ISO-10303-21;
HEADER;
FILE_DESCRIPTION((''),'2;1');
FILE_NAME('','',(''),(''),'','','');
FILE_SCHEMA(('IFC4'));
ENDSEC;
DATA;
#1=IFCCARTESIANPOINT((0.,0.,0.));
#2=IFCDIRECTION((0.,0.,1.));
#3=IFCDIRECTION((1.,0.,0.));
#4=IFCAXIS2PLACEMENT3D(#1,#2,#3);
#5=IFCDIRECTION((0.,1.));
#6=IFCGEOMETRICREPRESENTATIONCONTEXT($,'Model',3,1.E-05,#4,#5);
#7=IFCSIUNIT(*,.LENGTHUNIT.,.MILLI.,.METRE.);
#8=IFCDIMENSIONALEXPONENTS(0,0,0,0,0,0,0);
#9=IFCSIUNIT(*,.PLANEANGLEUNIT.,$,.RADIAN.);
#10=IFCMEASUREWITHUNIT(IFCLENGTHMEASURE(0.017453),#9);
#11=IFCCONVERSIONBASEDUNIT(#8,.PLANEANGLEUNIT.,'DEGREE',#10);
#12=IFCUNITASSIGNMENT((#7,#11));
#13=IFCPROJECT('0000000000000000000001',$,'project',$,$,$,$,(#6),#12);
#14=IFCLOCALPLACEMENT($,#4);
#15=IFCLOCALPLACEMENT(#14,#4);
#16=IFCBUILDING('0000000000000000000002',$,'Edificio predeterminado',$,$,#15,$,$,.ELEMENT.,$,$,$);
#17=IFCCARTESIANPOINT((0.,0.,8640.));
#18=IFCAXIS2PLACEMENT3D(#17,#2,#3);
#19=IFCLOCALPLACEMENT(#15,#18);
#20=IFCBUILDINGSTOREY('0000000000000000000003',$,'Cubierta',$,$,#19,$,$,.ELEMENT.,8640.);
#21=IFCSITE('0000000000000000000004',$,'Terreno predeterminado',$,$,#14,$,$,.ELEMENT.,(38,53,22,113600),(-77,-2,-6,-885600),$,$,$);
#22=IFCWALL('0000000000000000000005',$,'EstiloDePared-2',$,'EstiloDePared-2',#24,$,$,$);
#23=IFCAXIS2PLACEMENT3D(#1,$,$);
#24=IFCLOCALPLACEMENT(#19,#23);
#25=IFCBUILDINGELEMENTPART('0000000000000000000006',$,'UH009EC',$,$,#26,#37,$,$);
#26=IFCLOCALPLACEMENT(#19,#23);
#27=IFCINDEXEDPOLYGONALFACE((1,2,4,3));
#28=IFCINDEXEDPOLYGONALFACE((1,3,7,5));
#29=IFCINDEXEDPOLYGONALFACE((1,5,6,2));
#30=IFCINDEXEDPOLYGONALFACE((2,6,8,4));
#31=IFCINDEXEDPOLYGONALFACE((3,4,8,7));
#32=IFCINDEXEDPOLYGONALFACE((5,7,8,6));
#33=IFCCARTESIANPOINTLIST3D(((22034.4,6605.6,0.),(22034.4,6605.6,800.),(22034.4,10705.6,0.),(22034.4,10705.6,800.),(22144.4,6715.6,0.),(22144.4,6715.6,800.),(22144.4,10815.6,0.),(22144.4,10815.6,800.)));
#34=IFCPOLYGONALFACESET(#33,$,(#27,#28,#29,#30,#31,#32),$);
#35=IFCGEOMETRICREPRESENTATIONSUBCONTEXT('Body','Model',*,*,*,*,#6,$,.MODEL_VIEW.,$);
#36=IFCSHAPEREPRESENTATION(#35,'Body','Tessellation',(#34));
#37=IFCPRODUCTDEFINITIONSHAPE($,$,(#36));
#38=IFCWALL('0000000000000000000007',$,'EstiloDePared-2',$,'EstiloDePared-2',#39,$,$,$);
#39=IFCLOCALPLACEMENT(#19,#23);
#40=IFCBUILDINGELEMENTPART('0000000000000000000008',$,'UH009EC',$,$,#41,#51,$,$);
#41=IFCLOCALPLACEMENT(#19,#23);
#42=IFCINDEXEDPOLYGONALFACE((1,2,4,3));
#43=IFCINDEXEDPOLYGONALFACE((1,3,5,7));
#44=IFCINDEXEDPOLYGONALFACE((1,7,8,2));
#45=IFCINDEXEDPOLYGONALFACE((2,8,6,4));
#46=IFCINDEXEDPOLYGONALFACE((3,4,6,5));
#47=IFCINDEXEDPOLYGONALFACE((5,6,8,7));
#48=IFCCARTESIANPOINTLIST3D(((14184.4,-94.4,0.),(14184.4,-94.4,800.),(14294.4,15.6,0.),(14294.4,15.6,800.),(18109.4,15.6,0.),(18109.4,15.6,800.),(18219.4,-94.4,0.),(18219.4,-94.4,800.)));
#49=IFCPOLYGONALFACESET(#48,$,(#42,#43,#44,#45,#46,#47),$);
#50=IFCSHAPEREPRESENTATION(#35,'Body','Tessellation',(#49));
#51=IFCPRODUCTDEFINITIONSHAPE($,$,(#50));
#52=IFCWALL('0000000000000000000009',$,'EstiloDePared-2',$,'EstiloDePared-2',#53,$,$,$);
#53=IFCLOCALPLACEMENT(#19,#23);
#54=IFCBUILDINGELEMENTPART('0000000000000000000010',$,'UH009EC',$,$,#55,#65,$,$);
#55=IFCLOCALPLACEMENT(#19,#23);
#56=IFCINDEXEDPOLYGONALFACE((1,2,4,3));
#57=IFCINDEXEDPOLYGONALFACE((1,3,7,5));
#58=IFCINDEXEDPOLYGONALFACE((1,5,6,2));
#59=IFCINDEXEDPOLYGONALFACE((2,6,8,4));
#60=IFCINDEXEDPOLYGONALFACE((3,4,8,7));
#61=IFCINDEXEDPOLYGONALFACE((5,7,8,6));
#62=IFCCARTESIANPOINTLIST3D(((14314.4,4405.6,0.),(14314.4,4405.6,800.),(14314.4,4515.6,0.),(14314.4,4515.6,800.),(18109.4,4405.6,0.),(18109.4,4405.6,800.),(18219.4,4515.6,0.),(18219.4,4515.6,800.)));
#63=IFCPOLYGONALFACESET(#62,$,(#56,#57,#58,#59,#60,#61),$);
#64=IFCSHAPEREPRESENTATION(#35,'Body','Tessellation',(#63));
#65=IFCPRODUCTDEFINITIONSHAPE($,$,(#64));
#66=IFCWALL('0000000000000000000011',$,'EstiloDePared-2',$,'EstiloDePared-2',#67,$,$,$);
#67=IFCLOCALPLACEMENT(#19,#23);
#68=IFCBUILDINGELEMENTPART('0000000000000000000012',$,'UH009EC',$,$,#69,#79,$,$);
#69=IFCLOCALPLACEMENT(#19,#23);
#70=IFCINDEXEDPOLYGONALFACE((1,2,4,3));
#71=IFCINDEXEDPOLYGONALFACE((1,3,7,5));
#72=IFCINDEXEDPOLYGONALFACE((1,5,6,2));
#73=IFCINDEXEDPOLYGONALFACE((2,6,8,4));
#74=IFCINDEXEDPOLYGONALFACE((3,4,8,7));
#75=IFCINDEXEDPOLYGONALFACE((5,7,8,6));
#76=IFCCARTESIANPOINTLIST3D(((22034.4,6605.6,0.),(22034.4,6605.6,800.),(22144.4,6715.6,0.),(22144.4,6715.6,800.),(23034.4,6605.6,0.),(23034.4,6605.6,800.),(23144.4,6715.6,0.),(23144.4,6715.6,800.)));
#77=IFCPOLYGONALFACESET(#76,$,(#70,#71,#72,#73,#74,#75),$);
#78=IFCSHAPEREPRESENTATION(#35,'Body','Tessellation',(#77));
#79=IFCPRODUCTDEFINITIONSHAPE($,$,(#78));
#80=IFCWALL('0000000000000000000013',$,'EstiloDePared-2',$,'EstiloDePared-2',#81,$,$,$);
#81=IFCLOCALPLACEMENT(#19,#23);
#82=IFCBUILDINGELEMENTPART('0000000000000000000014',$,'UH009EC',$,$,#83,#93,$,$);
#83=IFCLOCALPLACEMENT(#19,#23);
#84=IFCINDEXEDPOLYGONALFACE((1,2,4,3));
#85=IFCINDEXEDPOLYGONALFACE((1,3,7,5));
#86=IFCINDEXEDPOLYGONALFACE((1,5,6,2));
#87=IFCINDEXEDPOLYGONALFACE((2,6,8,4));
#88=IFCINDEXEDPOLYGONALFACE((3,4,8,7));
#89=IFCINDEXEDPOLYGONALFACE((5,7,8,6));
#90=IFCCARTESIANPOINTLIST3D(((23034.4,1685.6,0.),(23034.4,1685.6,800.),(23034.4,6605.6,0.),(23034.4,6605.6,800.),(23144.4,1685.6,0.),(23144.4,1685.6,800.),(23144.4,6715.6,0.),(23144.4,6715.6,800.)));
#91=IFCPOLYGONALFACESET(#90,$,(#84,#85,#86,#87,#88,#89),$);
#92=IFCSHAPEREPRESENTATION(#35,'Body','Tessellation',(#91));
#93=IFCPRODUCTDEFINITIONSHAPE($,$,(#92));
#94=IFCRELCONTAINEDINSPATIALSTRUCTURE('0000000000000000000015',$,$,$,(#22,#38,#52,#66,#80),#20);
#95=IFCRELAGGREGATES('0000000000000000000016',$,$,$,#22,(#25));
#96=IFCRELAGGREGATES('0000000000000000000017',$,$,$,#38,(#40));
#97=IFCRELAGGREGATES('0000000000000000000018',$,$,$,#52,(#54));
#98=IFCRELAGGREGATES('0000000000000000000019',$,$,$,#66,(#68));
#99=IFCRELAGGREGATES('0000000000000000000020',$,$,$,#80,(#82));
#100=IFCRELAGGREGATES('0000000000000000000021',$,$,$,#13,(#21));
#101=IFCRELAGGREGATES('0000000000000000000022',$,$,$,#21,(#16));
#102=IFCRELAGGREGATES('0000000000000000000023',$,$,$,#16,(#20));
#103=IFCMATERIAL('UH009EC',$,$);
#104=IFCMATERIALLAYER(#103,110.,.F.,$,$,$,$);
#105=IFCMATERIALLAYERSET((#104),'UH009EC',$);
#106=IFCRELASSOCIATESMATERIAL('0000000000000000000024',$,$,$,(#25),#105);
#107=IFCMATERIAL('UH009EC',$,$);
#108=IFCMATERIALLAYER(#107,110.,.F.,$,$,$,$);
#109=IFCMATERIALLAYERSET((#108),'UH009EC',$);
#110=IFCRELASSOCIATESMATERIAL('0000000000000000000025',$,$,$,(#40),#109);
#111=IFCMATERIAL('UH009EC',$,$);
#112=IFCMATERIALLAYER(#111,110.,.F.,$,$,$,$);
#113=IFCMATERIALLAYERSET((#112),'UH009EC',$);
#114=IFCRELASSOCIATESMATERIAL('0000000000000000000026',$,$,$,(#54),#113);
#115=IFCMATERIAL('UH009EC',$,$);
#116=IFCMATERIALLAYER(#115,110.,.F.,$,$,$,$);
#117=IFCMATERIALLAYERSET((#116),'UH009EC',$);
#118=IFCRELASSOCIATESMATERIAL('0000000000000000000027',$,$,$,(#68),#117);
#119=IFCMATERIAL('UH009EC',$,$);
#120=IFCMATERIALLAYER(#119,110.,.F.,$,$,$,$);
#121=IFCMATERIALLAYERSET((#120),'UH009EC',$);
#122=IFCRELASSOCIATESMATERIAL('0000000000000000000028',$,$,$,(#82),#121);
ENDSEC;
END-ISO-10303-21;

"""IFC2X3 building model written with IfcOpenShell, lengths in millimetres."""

from ifc_helpers import new_model, entity, si_unit, converted_unit, direction, frame, origin_with_axes, place, context, subcontext, project, spatial, polyline, outline, extrude, material, layer, layer_set, layer_usage, element, aggregate, save


model = new_model("IFC2X3")

# Units and contexts
model_context = context("Model", 3, precision=1e-05, world=origin_with_axes(), true_north=direction((0.0, 1.0)))
body_context = subcontext(model_context, "Body", "Model", "MODEL_VIEW")
ifc_project = project(units=[si_unit("LENGTHUNIT", "METRE", prefix="MILLI"), converted_unit("PLANEANGLEUNIT", "DEGREE", entity("IfcLengthMeasure", 0.017453), si_unit("PLANEANGLEUNIT", "RADIAN"), dimensions=[0, 0, 0, 0, 0, 0, 0])], contexts=[model_context])

# Site, building, storey
site_placement = place(None, origin_with_axes())
site = spatial("IfcSite", under=ifc_project, at=site_placement, Name="Terreno predeterminado", CompositionType="ELEMENT", RefLatitude=(38, 53, 22, 113600), RefLongitude=(-77, -2, -6, -885600))
building_placement = place(site_placement, origin_with_axes())
building = spatial("IfcBuilding", under=site, at=building_placement, Name="Edificio predeterminado", CompositionType="ELEMENT")
storey_placement = place(building_placement, frame((0.0, 0.0, 8640.0), z_axis=(0.0, 0.0, 1.0), x_axis=(1.0, 0.0, 0.0)))
storey = spatial("IfcBuildingStorey", under=building, at=storey_placement, Name="Cubierta", CompositionType="ELEMENT", Elevation=8640.0)

# Wall, building element part
wall_1_placement = place(storey_placement, frame((22089.4, 10760.6, 0.0), z_axis=(0.0, 0.0, 1.0), x_axis=(0.0, -1.0, 0.0)))
wall_1 = element("IfcWall", 1, at=wall_1_placement, inside=storey, Name="EstiloDePared-2", ObjectType="EstiloDePared-2")
ifc_material_1 = material(Name="UH009EC")
ifc_layer_1 = layer(ifc_material_1, 110.0, ventilated=False)
ifc_layer_set_1 = layer_set([ifc_layer_1], Name="UH009EC")
ifc_layer_usage_1 = layer_usage(ifc_layer_set_1, "AXIS2", "NEGATIVE", -55.0)
building_element_part_1_placement = place(wall_1_placement, origin_with_axes())
building_element_part_1 = element("IfcBuildingElementPart", 2, at=building_element_part_1_placement, material=ifc_layer_usage_1, Name="UH009EC", context=body_context, shape_type="SweptSolid", body=[
    extrude(outline(polyline([(4045.0, 55.0), (4155.0, -55.0), (55.0, -55.0), (-55.0, 55.0), (4045.0, 55.0)])), origin_with_axes(), (0.0, 0.0, 1.0), 800.0),
])
aggregate(wall_1, [building_element_part_1])

# Walls, building element parts
wall_2_placement = place(storey_placement, frame((18164.4, -39.4, 0.0), z_axis=(0.0, 0.0, 1.0), x_axis=(-1.0, 0.0, 0.0)))
wall_2 = element("IfcWall", 3, at=wall_2_placement, inside=storey, Name="EstiloDePared-2", ObjectType="EstiloDePared-2")
ifc_material_2 = material(Name="UH009EC")
ifc_layer_2 = layer(ifc_material_2, 110.0, ventilated=False)
ifc_layer_set_2 = layer_set([ifc_layer_2], Name="UH009EC")
ifc_layer_usage_2 = layer_usage(ifc_layer_set_2, "AXIS2", "NEGATIVE", -55.0)
building_element_part_2_placement = place(wall_2_placement, origin_with_axes())
building_element_part_2 = element("IfcBuildingElementPart", 4, at=building_element_part_2_placement, material=ifc_layer_usage_2, Name="UH009EC", context=body_context, shape_type="SweptSolid", body=[
    extrude(outline(polyline([(3980.0, 55.0), (3870.0, -55.0), (55.0, -55.0), (-55.0, 55.0), (3980.0, 55.0)])), origin_with_axes(), (0.0, 0.0, 1.0), 800.0),
])
aggregate(wall_2, [building_element_part_2])
wall_3_placement = place(storey_placement, frame((18164.4, 4460.6, 0.0), z_axis=(0.0, 0.0, 1.0), x_axis=(-1.0, 0.0, 0.0)))
wall_3 = element("IfcWall", 5, at=wall_3_placement, inside=storey, Name="EstiloDePared-2", ObjectType="EstiloDePared-2")
ifc_material_3 = material(Name="UH009EC")
ifc_layer_3 = layer(ifc_material_3, 110.0, ventilated=False)
ifc_layer_set_3 = layer_set([ifc_layer_3], Name="UH009EC")
ifc_layer_usage_3 = layer_usage(ifc_layer_set_3, "AXIS2", "NEGATIVE", -55.0)
building_element_part_3_placement = place(wall_3_placement, origin_with_axes())
building_element_part_3 = element("IfcBuildingElementPart", 6, at=building_element_part_3_placement, material=ifc_layer_usage_3, Name="UH009EC", context=body_context, shape_type="SweptSolid", body=[
    extrude(outline(polyline([(3850.0, 55.0), (3850.0, -55.0), (-55.0, -55.0), (55.0, 55.0), (3850.0, 55.0)])), origin_with_axes(), (0.0, 0.0, 1.0), 800.0),
])
aggregate(wall_3, [building_element_part_3])
wall_4_placement = place(storey_placement, frame((22089.4, 6660.6, 0.0), z_axis=(0.0, 0.0, 1.0), x_axis=(1.0, 0.0, 0.0)))
wall_4 = element("IfcWall", 7, at=wall_4_placement, inside=storey, Name="EstiloDePared-2", ObjectType="EstiloDePared-2")
ifc_material_4 = material(Name="UH009EC")
ifc_layer_4 = layer(ifc_material_4, 110.0, ventilated=False)
ifc_layer_set_4 = layer_set([ifc_layer_4], Name="UH009EC")
ifc_layer_usage_4 = layer_usage(ifc_layer_set_4, "AXIS2", "NEGATIVE", -55.0)
building_element_part_4_placement = place(wall_4_placement, origin_with_axes())
building_element_part_4 = element("IfcBuildingElementPart", 8, at=building_element_part_4_placement, material=ifc_layer_usage_4, Name="UH009EC", context=body_context, shape_type="SweptSolid", body=[
    extrude(outline(polyline([(1055.0, 55.0), (945.0, -55.0), (-55.0, -55.0), (55.0, 55.0), (1055.0, 55.0)])), origin_with_axes(), (0.0, 0.0, 1.0), 800.0),
])
aggregate(wall_4, [building_element_part_4])
wall_5_placement = place(storey_placement, frame((23089.4, 6660.6, 0.0), z_axis=(0.0, 0.0, 1.0), x_axis=(0.0, -1.0, 0.0)))
wall_5 = element("IfcWall", 9, at=wall_5_placement, inside=storey, Name="EstiloDePared-2", ObjectType="EstiloDePared-2")
ifc_material_5 = material(Name="UH009EC")
ifc_layer_5 = layer(ifc_material_5, 110.0, ventilated=False)
ifc_layer_set_5 = layer_set([ifc_layer_5], Name="UH009EC")
ifc_layer_usage_5 = layer_usage(ifc_layer_set_5, "AXIS2", "NEGATIVE", -55.0)
building_element_part_5_placement = place(wall_5_placement, origin_with_axes())
building_element_part_5 = element("IfcBuildingElementPart", 10, at=building_element_part_5_placement, material=ifc_layer_usage_5, Name="UH009EC", context=body_context, shape_type="SweptSolid", body=[
    extrude(outline(polyline([(4975.0, 55.0), (4975.0, -55.0), (55.0, -55.0), (-55.0, 55.0), (4975.0, 55.0)])), origin_with_axes(), (0.0, 0.0, 1.0), 800.0),
])
aggregate(wall_5, [building_element_part_5])

save(model, "model.ifc")
